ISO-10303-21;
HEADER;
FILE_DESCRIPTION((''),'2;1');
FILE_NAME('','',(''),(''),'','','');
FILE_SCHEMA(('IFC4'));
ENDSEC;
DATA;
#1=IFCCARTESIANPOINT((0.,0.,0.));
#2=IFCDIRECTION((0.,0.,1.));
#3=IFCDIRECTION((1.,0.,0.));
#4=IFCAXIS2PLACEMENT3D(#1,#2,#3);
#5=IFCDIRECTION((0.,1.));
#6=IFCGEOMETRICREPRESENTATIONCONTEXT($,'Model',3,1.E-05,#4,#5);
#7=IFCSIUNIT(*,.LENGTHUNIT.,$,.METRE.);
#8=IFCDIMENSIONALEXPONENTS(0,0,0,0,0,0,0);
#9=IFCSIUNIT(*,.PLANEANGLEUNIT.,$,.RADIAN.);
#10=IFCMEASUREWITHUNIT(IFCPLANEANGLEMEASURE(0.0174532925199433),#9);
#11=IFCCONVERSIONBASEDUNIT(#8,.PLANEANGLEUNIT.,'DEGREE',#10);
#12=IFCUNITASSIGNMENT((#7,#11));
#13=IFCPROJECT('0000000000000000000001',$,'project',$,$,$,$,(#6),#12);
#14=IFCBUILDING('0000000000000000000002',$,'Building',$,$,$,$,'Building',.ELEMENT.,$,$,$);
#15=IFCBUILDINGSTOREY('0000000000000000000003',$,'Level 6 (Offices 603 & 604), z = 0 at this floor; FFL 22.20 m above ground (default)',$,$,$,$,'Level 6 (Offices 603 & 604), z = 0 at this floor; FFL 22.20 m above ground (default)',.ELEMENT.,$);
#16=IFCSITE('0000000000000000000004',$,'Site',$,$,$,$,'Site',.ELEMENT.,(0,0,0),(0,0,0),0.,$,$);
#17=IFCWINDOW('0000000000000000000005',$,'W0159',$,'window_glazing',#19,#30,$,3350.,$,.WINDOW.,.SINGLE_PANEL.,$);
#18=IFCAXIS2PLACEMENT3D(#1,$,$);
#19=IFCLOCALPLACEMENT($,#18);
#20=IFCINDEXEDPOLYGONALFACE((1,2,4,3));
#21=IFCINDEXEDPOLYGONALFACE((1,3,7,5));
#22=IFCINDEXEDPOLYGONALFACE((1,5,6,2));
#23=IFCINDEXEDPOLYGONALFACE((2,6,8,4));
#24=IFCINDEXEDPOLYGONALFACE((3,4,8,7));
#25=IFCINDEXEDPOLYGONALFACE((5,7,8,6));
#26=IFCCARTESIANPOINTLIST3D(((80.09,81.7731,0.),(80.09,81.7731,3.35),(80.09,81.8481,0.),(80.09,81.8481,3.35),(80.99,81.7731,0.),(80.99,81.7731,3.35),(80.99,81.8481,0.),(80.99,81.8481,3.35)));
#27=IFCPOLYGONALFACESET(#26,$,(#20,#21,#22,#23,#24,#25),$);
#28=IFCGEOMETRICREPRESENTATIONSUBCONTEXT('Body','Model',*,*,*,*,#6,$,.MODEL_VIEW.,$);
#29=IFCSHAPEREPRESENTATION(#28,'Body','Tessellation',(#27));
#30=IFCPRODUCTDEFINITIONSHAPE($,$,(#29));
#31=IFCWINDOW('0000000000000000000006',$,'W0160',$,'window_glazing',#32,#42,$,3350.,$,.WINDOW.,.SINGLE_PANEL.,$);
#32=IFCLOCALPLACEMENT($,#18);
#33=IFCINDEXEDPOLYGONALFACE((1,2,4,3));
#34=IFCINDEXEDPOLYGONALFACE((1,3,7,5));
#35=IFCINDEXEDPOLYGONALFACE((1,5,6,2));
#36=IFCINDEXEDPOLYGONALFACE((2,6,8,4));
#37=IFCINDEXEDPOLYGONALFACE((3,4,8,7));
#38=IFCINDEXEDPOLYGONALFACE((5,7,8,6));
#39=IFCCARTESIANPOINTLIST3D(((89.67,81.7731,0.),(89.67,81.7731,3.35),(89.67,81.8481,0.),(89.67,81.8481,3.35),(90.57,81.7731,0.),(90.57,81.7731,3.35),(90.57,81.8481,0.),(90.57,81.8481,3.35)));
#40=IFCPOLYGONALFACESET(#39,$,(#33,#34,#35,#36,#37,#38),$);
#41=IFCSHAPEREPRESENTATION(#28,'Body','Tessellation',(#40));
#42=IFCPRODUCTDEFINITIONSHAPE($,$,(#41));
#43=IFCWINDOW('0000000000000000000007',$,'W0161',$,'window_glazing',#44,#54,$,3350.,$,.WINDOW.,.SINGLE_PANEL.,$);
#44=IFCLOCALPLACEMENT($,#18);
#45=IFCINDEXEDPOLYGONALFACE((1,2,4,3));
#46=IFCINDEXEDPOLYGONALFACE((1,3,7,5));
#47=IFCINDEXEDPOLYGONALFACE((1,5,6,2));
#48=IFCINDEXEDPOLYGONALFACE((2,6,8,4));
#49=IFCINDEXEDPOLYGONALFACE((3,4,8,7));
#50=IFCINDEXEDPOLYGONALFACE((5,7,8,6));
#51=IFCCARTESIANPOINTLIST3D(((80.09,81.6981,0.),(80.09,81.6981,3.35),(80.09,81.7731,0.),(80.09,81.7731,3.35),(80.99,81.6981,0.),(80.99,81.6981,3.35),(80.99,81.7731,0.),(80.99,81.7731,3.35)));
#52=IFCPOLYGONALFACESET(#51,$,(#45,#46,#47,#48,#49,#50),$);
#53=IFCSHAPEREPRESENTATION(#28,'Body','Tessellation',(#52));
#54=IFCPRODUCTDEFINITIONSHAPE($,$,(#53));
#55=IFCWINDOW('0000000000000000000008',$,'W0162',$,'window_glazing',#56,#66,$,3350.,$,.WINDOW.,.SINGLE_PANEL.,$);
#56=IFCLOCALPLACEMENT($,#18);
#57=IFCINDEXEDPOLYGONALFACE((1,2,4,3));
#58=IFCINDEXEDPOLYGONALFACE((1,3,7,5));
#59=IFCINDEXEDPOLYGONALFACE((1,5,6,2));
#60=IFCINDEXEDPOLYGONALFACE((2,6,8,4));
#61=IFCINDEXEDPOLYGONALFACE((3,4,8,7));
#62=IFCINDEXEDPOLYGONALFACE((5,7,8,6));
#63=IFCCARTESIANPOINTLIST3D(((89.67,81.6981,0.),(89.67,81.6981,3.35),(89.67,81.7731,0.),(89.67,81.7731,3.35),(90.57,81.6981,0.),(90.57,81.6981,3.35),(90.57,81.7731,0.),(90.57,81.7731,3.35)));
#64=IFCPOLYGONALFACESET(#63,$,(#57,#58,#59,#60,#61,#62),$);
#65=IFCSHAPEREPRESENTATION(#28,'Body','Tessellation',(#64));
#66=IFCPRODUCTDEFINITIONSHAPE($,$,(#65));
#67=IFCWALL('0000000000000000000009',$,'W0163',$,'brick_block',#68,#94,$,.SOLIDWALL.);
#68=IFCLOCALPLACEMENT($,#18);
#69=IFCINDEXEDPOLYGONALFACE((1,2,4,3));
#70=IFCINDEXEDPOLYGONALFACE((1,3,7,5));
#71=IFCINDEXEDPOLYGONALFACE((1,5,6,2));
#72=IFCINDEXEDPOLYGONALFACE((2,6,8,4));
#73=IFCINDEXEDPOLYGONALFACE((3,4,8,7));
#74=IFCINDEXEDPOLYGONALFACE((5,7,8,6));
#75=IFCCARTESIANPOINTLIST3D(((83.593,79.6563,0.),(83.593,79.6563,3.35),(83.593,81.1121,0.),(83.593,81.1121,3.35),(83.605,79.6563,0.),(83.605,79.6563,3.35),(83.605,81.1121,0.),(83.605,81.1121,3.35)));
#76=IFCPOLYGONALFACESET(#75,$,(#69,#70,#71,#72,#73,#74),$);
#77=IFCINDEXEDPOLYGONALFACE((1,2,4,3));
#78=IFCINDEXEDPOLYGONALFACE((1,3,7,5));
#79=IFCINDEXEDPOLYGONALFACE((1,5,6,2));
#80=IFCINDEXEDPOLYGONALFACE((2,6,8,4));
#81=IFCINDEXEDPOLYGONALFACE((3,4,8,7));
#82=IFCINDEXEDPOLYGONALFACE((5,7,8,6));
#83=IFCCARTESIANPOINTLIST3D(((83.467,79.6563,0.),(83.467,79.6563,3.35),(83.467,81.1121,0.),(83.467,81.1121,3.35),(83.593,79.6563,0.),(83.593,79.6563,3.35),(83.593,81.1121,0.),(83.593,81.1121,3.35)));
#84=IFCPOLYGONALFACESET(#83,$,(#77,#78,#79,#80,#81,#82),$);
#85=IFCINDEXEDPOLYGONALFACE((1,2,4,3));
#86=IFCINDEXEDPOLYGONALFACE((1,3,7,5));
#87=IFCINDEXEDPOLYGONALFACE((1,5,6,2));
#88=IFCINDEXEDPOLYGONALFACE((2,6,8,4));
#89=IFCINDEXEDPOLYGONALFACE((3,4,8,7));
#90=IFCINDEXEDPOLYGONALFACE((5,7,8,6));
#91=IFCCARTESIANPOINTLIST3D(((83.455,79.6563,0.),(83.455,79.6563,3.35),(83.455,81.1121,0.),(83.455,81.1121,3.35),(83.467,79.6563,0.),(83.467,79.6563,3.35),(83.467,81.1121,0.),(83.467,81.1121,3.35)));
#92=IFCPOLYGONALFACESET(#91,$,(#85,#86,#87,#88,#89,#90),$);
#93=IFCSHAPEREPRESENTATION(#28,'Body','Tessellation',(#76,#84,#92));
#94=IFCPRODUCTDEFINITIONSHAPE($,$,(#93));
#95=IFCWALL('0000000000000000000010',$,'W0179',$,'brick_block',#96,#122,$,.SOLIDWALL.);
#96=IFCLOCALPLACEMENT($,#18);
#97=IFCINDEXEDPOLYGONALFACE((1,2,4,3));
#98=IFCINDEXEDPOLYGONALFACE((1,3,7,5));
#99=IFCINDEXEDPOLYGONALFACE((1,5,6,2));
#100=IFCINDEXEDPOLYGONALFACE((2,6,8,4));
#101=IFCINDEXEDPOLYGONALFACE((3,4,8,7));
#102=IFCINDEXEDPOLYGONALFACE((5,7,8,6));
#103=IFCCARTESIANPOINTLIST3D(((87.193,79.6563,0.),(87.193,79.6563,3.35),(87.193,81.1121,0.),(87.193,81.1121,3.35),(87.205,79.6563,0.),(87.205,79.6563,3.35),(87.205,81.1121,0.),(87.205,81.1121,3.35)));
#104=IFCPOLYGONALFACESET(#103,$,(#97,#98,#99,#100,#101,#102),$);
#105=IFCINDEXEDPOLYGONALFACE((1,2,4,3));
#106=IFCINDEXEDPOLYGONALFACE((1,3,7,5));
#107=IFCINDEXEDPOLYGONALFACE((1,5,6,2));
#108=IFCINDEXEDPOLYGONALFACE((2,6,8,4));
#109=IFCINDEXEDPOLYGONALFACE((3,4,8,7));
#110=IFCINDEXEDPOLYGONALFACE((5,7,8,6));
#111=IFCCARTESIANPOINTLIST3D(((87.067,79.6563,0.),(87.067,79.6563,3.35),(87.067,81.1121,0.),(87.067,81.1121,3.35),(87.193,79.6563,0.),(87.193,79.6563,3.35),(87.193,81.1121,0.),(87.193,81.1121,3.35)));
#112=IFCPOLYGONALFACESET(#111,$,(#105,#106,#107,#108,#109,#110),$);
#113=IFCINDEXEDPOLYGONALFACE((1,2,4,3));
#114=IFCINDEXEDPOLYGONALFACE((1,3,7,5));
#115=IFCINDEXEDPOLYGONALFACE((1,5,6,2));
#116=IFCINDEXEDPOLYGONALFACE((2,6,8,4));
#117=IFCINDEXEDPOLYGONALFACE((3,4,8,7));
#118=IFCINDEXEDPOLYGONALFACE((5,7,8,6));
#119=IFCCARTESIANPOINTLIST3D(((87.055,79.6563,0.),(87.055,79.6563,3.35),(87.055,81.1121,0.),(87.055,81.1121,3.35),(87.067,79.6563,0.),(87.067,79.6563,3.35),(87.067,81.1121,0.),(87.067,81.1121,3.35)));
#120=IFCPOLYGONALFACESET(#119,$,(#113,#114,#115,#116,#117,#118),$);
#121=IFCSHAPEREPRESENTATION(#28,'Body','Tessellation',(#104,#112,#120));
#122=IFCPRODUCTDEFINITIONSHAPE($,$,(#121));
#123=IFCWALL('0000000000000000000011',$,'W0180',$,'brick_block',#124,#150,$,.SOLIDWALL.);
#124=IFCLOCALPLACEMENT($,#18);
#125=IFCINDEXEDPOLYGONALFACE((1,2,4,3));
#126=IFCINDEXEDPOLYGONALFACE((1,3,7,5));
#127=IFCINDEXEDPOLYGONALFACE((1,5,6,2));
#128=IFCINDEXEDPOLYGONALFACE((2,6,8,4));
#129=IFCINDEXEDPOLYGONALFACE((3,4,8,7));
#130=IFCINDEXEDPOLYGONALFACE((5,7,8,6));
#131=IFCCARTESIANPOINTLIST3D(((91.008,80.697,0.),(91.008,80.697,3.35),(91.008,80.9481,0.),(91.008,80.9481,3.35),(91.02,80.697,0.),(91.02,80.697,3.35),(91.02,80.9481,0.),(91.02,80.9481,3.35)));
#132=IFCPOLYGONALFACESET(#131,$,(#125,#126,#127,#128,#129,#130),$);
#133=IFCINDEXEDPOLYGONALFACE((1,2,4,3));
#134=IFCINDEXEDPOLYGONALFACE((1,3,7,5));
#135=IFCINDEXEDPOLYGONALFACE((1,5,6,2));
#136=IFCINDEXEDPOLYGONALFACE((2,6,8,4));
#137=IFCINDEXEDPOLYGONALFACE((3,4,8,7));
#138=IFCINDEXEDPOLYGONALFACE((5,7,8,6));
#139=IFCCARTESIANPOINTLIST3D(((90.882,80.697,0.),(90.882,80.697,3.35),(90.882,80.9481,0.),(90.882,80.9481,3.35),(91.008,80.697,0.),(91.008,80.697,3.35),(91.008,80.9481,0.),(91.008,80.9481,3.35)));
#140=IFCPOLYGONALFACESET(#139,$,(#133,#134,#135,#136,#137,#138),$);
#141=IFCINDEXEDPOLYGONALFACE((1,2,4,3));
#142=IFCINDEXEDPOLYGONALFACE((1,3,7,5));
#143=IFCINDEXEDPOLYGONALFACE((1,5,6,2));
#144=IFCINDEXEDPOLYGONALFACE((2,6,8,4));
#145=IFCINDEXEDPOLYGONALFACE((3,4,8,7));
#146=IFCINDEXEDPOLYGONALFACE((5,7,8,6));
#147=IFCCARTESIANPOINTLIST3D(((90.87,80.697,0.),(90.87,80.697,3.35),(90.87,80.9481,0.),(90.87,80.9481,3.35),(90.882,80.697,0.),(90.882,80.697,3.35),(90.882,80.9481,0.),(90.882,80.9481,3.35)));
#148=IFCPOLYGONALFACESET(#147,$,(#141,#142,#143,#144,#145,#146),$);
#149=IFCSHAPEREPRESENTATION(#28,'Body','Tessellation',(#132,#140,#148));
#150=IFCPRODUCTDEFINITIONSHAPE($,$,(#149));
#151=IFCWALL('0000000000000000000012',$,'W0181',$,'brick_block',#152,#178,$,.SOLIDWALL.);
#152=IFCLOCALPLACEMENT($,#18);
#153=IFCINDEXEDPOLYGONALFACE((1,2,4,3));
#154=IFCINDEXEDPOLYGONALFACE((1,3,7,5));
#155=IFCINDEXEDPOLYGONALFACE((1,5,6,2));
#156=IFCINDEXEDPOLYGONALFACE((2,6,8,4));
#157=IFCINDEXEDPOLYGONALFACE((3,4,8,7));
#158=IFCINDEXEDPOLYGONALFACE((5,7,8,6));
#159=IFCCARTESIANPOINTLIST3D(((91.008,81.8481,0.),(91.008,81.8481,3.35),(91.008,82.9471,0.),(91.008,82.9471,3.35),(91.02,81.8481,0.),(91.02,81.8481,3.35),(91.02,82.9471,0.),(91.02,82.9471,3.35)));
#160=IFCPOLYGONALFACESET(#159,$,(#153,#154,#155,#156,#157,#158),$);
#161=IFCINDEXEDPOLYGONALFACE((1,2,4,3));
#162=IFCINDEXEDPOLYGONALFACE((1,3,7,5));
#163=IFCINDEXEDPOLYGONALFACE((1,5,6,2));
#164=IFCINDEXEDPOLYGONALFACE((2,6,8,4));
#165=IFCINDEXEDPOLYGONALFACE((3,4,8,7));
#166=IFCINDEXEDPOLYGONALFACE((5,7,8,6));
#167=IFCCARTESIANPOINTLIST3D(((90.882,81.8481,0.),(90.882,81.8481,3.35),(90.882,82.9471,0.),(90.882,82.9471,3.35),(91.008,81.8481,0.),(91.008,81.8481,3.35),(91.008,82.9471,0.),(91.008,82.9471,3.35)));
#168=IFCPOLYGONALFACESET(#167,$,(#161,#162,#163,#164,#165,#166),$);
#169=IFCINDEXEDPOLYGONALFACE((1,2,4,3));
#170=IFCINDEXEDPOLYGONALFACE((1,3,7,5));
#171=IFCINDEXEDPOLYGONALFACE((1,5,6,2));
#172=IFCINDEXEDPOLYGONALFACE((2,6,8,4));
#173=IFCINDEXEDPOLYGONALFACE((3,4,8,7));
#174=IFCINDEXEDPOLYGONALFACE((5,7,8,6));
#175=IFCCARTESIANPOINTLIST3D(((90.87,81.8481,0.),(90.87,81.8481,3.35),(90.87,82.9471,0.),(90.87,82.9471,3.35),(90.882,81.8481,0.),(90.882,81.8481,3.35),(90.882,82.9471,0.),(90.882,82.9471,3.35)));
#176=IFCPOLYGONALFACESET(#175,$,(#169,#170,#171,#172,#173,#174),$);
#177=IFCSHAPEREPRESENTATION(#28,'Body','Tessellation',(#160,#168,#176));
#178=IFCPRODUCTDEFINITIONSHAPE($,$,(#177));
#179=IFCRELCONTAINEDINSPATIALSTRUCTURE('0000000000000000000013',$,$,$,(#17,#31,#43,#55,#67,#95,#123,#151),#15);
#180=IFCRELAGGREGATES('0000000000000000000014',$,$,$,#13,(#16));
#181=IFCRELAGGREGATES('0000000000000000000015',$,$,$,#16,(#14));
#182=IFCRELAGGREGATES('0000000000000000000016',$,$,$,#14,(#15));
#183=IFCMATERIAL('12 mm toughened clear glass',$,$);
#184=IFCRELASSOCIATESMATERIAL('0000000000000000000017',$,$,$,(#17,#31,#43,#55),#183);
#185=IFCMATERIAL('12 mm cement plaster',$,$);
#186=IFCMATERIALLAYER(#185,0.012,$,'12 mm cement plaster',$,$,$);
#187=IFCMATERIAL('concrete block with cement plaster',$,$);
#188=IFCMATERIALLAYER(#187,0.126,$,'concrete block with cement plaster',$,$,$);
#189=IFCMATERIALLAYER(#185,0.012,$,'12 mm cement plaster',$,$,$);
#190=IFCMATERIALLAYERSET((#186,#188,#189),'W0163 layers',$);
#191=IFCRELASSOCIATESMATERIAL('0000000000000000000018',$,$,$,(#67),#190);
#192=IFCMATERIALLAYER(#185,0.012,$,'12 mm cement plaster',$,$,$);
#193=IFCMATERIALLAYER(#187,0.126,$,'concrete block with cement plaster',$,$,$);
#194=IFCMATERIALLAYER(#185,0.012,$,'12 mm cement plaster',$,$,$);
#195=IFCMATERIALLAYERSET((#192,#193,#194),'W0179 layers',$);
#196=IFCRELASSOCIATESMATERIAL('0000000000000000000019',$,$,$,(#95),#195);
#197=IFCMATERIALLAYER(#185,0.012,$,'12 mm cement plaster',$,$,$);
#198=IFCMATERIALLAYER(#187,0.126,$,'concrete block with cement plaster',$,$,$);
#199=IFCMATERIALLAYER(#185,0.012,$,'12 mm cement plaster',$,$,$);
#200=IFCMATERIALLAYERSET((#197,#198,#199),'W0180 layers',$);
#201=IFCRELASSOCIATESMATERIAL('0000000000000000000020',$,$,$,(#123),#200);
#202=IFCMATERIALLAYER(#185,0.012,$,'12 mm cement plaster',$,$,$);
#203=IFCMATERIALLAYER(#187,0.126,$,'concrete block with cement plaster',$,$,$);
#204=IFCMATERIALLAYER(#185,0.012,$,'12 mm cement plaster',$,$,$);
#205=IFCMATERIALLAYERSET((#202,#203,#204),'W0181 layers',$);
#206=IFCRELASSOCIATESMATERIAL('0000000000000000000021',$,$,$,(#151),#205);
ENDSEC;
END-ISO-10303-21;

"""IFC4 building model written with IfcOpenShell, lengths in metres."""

from ifc_helpers import new_model, entity, si_unit, converted_unit, direction, frame, frame_2d, origin_with_axes, place, context, subcontext, project, spatial, rectangle, extrude, material, layer, layer_set, layer_usage, element, save


model = new_model("IFC4")

# Units and contexts
model_context = context("Model", 3, precision=1e-05, world=origin_with_axes(), true_north=direction((0.0, 1.0)))
body_context = subcontext(model_context, "Body", "Model", "MODEL_VIEW")
ifc_project = project(units=[si_unit("LENGTHUNIT", "METRE"), converted_unit("PLANEANGLEUNIT", "DEGREE", entity("IfcPlaneAngleMeasure", 0.0174532925199433), si_unit("PLANEANGLEUNIT", "RADIAN"), dimensions=[0, 0, 0, 0, 0, 0, 0])], contexts=[model_context])

# Site, building, storey
site = spatial("IfcSite", under=ifc_project, Name="Site", LongName="Site", CompositionType="ELEMENT", RefLatitude=(0, 0, 0), RefLongitude=(0, 0, 0), RefElevation=0.0)
building = spatial("IfcBuilding", under=site, Name="Building", LongName="Building", CompositionType="ELEMENT")
storey = spatial("IfcBuildingStorey", under=building, Name="Level 6 (Offices 603 & 604), z = 0 at this floor; FFL 22.20 m above ground (default)", LongName="Level 6 (Offices 603 & 604), z = 0 at this floor; FFL 22.20 m above ground (default)", CompositionType="ELEMENT")

# Windows
ifc_material_1 = material(Name="12 mm toughened clear glass")
placement = place(None, origin_with_axes())
element("IfcWindow", 1, at=placement, inside=storey, material=ifc_material_1, Name="W0159", ObjectType="window_glazing", OverallHeight=3350.0, PartitioningType="SINGLE_PANEL", PredefinedType="WINDOW", context=body_context, shape_type="SweptSolid", body=[
    extrude(rectangle(XDim=0.9, YDim=0.075, at=frame_2d((0.0, 0.0), x_axis=(1.0, 0.0))), frame((80.54, 81.8106, 0.0), z_axis=(0.0, 0.0, 1.0), x_axis=(1.0, 0.0, 0.0)), (0.0, 0.0, 1.0), 3.35),
])
element("IfcWindow", 2, at=placement, inside=storey, material=ifc_material_1, Name="W0160", ObjectType="window_glazing", OverallHeight=3350.0, PartitioningType="SINGLE_PANEL", PredefinedType="WINDOW", context=body_context, shape_type="SweptSolid", body=[
    extrude(rectangle(XDim=0.9, YDim=0.075, at=frame_2d((0.0, 0.0), x_axis=(1.0, 0.0))), frame((90.12, 81.8106, 0.0), z_axis=(0.0, 0.0, 1.0), x_axis=(1.0, 0.0, 0.0)), (0.0, 0.0, 1.0), 3.35),
])
element("IfcWindow", 3, at=placement, inside=storey, material=ifc_material_1, Name="W0161", ObjectType="window_glazing", OverallHeight=3350.0, PartitioningType="SINGLE_PANEL", PredefinedType="WINDOW", context=body_context, shape_type="SweptSolid", body=[
    extrude(rectangle(XDim=0.9, YDim=0.075, at=frame_2d((0.0, 0.0), x_axis=(1.0, 0.0))), frame((80.54, 81.7356, 0.0), z_axis=(0.0, 0.0, 1.0), x_axis=(1.0, 0.0, 0.0)), (0.0, 0.0, 1.0), 3.35),
])
element("IfcWindow", 4, at=placement, inside=storey, material=ifc_material_1, Name="W0162", ObjectType="window_glazing", OverallHeight=3350.0, PartitioningType="SINGLE_PANEL", PredefinedType="WINDOW", context=body_context, shape_type="SweptSolid", body=[
    extrude(rectangle(XDim=0.9, YDim=0.075, at=frame_2d((0.0, 0.0), x_axis=(1.0, 0.0))), frame((90.12, 81.7356, 0.0), z_axis=(0.0, 0.0, 1.0), x_axis=(1.0, 0.0, 0.0)), (0.0, 0.0, 1.0), 3.35),
])

# Walls
ifc_material_2 = material(Name="12 mm cement plaster")
ifc_layer_1 = layer(ifc_material_2, 0.012, Name="12 mm cement plaster")
ifc_material_3 = material(Name="concrete block with cement plaster")
ifc_layer_2 = layer(ifc_material_3, 0.126, Name="concrete block with cement plaster")
ifc_layer_3 = layer(ifc_material_2, 0.012, Name="12 mm cement plaster")
ifc_layer_set_1 = layer_set([ifc_layer_1, ifc_layer_2, ifc_layer_3], Name="W0163 layers")
ifc_layer_usage_1 = layer_usage(ifc_layer_set_1, "AXIS2", "POSITIVE", -0.075)
element("IfcWall", 5, at=placement, inside=storey, material=ifc_layer_usage_1, Name="W0163", ObjectType="brick_block", PredefinedType="SOLIDWALL", context=body_context, shape_type="SweptSolid", body=[
    extrude(rectangle(XDim=1.4558, YDim=0.012, at=frame_2d((0.0, 0.0), x_axis=(0.0, 1.0))), frame((83.599, 80.3842, 0.0), z_axis=(0.0, 0.0, 1.0), x_axis=(1.0, 0.0, 0.0)), (0.0, 0.0, 1.0), 3.35),
    extrude(rectangle(XDim=1.4558, YDim=0.126, at=frame_2d((-0.069, 0.0), x_axis=(0.0, 1.0))), frame((83.599, 80.3842, 0.0), z_axis=(0.0, 0.0, 1.0), x_axis=(1.0, 0.0, 0.0)), (0.0, 0.0, 1.0), 3.35),
    extrude(rectangle(XDim=1.4558, YDim=0.012, at=frame_2d((-0.138, 0.0), x_axis=(0.0, 1.0))), frame((83.599, 80.3842, 0.0), z_axis=(0.0, 0.0, 1.0), x_axis=(1.0, 0.0, 0.0)), (0.0, 0.0, 1.0), 3.35),
])
ifc_layer_4 = layer(ifc_material_2, 0.012, Name="12 mm cement plaster")
ifc_layer_5 = layer(ifc_material_3, 0.126, Name="concrete block with cement plaster")
ifc_layer_6 = layer(ifc_material_2, 0.012, Name="12 mm cement plaster")
ifc_layer_set_2 = layer_set([ifc_layer_4, ifc_layer_5, ifc_layer_6], Name="W0179 layers")
ifc_layer_usage_2 = layer_usage(ifc_layer_set_2, "AXIS2", "POSITIVE", -0.075)
element("IfcWall", 6, at=placement, inside=storey, material=ifc_layer_usage_2, Name="W0179", ObjectType="brick_block", PredefinedType="SOLIDWALL", context=body_context, shape_type="SweptSolid", body=[
    extrude(rectangle(XDim=1.4558, YDim=0.012, at=frame_2d((0.0, 0.0), x_axis=(0.0, 1.0))), frame((87.199, 80.3842, 0.0), z_axis=(0.0, 0.0, 1.0), x_axis=(1.0, 0.0, 0.0)), (0.0, 0.0, 1.0), 3.35),
    extrude(rectangle(XDim=1.4558, YDim=0.126, at=frame_2d((-0.069, 0.0), x_axis=(0.0, 1.0))), frame((87.199, 80.3842, 0.0), z_axis=(0.0, 0.0, 1.0), x_axis=(1.0, 0.0, 0.0)), (0.0, 0.0, 1.0), 3.35),
    extrude(rectangle(XDim=1.4558, YDim=0.012, at=frame_2d((-0.138, 0.0), x_axis=(0.0, 1.0))), frame((87.199, 80.3842, 0.0), z_axis=(0.0, 0.0, 1.0), x_axis=(1.0, 0.0, 0.0)), (0.0, 0.0, 1.0), 3.35),
])
ifc_layer_7 = layer(ifc_material_2, 0.012, Name="12 mm cement plaster")
ifc_layer_8 = layer(ifc_material_3, 0.126, Name="concrete block with cement plaster")
ifc_layer_9 = layer(ifc_material_2, 0.012, Name="12 mm cement plaster")
ifc_layer_set_3 = layer_set([ifc_layer_7, ifc_layer_8, ifc_layer_9], Name="W0180 layers")
ifc_layer_usage_3 = layer_usage(ifc_layer_set_3, "AXIS2", "POSITIVE", -0.075)
element("IfcWall", 7, at=placement, inside=storey, material=ifc_layer_usage_3, Name="W0180", ObjectType="brick_block", PredefinedType="SOLIDWALL", context=body_context, shape_type="SweptSolid", body=[
    extrude(rectangle(XDim=0.2511, YDim=0.012, at=frame_2d((0.0, 0.0), x_axis=(0.0, 1.0))), frame((91.014, 80.8226, 0.0), z_axis=(0.0, 0.0, 1.0), x_axis=(1.0, 0.0, 0.0)), (0.0, 0.0, 1.0), 3.35),
    extrude(rectangle(XDim=0.2511, YDim=0.126, at=frame_2d((-0.069, 0.0), x_axis=(0.0, 1.0))), frame((91.014, 80.8226, 0.0), z_axis=(0.0, 0.0, 1.0), x_axis=(1.0, 0.0, 0.0)), (0.0, 0.0, 1.0), 3.35),
    extrude(rectangle(XDim=0.2511, YDim=0.012, at=frame_2d((-0.138, 0.0), x_axis=(0.0, 1.0))), frame((91.014, 80.8226, 0.0), z_axis=(0.0, 0.0, 1.0), x_axis=(1.0, 0.0, 0.0)), (0.0, 0.0, 1.0), 3.35),
])
ifc_layer_10 = layer(ifc_material_2, 0.012, Name="12 mm cement plaster")
ifc_layer_11 = layer(ifc_material_3, 0.126, Name="concrete block with cement plaster")
ifc_layer_12 = layer(ifc_material_2, 0.012, Name="12 mm cement plaster")
ifc_layer_set_4 = layer_set([ifc_layer_10, ifc_layer_11, ifc_layer_12], Name="W0181 layers")
ifc_layer_usage_4 = layer_usage(ifc_layer_set_4, "AXIS2", "POSITIVE", -0.075)
element("IfcWall", 8, at=placement, inside=storey, material=ifc_layer_usage_4, Name="W0181", ObjectType="brick_block", PredefinedType="SOLIDWALL", context=body_context, shape_type="SweptSolid", body=[
    extrude(rectangle(XDim=1.099, YDim=0.012, at=frame_2d((0.0, 0.0), x_axis=(0.0, 1.0))), frame((91.014, 82.3976, 0.0), z_axis=(0.0, 0.0, 1.0), x_axis=(1.0, 0.0, 0.0)), (0.0, 0.0, 1.0), 3.35),
    extrude(rectangle(XDim=1.099, YDim=0.126, at=frame_2d((-0.069, 0.0), x_axis=(0.0, 1.0))), frame((91.014, 82.3976, 0.0), z_axis=(0.0, 0.0, 1.0), x_axis=(1.0, 0.0, 0.0)), (0.0, 0.0, 1.0), 3.35),
    extrude(rectangle(XDim=1.099, YDim=0.012, at=frame_2d((-0.138, 0.0), x_axis=(0.0, 1.0))), frame((91.014, 82.3976, 0.0), z_axis=(0.0, 0.0, 1.0), x_axis=(1.0, 0.0, 0.0)), (0.0, 0.0, 1.0), 3.35),
])

save(model, "model.ifc")
